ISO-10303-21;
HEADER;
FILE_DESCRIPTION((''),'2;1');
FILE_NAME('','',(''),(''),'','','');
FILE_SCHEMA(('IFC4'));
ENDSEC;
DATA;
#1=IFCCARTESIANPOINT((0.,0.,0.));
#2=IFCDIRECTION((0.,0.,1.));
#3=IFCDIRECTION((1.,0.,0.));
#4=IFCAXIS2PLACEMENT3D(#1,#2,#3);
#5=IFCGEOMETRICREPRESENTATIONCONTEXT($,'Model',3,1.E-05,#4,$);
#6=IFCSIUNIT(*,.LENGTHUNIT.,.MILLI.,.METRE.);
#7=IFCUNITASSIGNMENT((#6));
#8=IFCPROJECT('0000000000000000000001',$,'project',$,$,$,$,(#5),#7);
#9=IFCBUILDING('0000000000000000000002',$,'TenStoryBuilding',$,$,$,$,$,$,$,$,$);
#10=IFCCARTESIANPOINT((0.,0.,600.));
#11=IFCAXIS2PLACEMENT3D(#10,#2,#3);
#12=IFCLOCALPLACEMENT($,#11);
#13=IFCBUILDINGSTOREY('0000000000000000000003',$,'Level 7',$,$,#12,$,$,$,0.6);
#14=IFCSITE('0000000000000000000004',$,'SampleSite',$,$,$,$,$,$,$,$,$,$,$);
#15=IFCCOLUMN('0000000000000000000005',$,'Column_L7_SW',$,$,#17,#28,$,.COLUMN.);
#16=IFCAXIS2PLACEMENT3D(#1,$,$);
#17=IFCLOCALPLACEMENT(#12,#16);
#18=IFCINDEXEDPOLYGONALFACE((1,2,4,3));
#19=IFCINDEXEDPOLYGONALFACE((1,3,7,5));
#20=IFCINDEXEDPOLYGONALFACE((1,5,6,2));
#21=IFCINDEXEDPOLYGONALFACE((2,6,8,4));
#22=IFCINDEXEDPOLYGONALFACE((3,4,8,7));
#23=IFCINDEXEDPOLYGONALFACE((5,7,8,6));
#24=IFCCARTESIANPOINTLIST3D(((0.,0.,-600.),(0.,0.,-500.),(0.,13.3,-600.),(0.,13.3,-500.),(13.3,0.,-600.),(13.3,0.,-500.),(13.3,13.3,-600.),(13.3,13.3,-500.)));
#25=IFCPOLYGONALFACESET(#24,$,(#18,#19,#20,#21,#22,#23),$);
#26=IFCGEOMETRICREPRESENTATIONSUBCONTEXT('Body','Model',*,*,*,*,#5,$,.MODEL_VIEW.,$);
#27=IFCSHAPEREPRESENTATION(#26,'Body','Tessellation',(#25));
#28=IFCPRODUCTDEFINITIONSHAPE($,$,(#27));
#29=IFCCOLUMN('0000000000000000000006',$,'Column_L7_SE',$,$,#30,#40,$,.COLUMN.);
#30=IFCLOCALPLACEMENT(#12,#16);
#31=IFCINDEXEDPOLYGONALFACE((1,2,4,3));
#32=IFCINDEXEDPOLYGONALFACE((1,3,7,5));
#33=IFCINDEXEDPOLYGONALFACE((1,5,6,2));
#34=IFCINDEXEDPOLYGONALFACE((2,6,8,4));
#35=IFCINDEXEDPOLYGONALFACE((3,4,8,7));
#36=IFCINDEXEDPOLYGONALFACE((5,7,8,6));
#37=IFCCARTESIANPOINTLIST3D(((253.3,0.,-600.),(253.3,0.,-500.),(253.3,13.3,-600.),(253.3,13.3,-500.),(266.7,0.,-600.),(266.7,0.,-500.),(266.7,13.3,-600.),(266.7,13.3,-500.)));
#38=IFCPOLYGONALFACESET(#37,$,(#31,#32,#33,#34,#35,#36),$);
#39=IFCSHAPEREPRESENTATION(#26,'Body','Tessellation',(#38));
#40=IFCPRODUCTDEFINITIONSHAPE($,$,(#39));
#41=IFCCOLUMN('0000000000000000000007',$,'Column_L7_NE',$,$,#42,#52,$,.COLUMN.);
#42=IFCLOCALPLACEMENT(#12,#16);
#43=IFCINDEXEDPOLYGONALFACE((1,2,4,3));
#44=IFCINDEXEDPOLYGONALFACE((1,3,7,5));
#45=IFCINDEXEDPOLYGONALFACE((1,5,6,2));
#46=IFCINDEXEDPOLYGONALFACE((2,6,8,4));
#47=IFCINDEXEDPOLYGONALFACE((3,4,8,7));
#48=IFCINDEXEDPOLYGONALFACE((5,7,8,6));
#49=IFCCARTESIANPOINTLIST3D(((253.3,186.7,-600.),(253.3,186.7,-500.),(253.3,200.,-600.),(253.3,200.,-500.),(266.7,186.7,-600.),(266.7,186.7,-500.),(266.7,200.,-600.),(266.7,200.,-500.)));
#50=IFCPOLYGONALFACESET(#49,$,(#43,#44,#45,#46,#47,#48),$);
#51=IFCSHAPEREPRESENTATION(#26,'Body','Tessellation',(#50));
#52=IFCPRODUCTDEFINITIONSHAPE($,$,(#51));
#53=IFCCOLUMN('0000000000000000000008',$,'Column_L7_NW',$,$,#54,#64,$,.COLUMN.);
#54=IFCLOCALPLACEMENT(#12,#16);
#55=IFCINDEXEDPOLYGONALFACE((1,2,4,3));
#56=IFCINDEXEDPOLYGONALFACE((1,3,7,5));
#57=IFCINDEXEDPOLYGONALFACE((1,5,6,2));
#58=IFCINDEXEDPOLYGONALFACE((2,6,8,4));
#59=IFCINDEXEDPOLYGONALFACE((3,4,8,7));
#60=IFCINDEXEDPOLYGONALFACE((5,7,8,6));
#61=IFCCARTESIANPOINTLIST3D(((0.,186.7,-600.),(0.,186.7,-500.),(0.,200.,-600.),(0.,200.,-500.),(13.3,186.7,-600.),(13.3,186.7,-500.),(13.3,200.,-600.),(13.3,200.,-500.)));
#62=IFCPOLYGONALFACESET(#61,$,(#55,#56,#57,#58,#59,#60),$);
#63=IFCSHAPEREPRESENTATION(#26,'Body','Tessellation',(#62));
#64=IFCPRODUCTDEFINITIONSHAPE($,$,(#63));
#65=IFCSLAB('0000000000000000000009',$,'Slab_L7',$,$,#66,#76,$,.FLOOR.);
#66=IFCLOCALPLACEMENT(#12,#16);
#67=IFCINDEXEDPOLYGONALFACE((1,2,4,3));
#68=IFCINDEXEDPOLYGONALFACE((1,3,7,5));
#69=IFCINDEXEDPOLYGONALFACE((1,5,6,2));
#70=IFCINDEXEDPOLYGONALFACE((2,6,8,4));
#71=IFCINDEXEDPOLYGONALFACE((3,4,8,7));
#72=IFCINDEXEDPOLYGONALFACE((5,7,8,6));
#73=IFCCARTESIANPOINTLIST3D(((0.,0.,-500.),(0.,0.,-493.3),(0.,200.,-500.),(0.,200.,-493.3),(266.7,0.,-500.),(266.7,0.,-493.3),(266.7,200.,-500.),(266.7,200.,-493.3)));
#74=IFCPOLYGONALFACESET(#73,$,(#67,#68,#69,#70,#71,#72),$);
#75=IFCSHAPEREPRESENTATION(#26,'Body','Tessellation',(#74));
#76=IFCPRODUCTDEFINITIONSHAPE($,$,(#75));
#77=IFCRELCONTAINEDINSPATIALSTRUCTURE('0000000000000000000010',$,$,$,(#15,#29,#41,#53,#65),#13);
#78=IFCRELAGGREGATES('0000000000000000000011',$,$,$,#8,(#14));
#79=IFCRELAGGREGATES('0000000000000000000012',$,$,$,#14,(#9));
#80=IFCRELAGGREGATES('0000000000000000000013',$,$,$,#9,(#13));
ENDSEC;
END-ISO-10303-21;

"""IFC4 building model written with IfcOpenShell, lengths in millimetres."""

from ifc_helpers import new_model, si_unit, frame, origin_with_axes, origin_2d, place, context, subcontext, project, spatial, indexed_curve, rectangle, outline, extrude, element, save


model = new_model("IFC4")

# Units and contexts
model_context = context("Model", 3, precision=1e-05, world=origin_with_axes())
body_context = subcontext(model_context, "Body", "Model", "MODEL_VIEW")
ifc_project = project(units=[si_unit("LENGTHUNIT", "METRE", prefix="MILLI")], contexts=[model_context])

# Site, building, storey
site = spatial("IfcSite", under=ifc_project, Name="SampleSite")
building = spatial("IfcBuilding", under=site, Name="TenStoryBuilding")
storey_placement = place(None, frame((0.0, 0.0, 600.0), z_axis=(0.0, 0.0, 1.0), x_axis=(1.0, 0.0, 0.0)))
storey = spatial("IfcBuildingStorey", under=building, at=storey_placement, Name="Level 7", Elevation=0.6)

# Columns
for number, where, z_axis, x_axis, name in (
    (1, (6.7, 6.7, -600.0), (0.0, 0.0, 1.0), (1.0, 0.0, 0.0), "Column_L7_SW"),
    (2, (260.0, 6.7, -600.0), (0.0, 0.0, 1.0), (1.0, 0.0, 0.0), "Column_L7_SE"),
    (3, (260.0, 193.3, -600.0), (0.0, 0.0, 1.0), (1.0, 0.0, 0.0), "Column_L7_NE"),
    (4, (6.7, 193.3, -600.0), (0.0, 0.0, 1.0), (1.0, 0.0, 0.0), "Column_L7_NW"),
):
    element("IfcColumn", number, at=place(storey_placement, frame(where, z_axis=z_axis, x_axis=x_axis)), inside=storey, Name=name, PredefinedType="COLUMN", context=body_context, shape_type="SweptSolid", body=[
        extrude(rectangle(XDim=13.3, YDim=13.3, at=origin_2d()), origin_with_axes(), (0.0, 0.0, 1.0), 100.0),
    ])

# Slab
slab_placement = place(storey_placement, frame((0.0, 0.0, -500.0), z_axis=(0.0, 0.0, 1.0), x_axis=(1.0, 0.0, 0.0)))
element("IfcSlab", 5, at=slab_placement, inside=storey, Name="Slab_L7", PredefinedType="FLOOR", context=body_context, shape_type="SweptSolid", body=[
    extrude(outline(indexed_curve([(0.0, 0.0), (266.7, 0.0), (266.7, 200.0), (0.0, 200.0), (0.0, 0.0)])), None, (0.0, 0.0, 1.0), 6.7),
])

save(model, "model.ifc")
